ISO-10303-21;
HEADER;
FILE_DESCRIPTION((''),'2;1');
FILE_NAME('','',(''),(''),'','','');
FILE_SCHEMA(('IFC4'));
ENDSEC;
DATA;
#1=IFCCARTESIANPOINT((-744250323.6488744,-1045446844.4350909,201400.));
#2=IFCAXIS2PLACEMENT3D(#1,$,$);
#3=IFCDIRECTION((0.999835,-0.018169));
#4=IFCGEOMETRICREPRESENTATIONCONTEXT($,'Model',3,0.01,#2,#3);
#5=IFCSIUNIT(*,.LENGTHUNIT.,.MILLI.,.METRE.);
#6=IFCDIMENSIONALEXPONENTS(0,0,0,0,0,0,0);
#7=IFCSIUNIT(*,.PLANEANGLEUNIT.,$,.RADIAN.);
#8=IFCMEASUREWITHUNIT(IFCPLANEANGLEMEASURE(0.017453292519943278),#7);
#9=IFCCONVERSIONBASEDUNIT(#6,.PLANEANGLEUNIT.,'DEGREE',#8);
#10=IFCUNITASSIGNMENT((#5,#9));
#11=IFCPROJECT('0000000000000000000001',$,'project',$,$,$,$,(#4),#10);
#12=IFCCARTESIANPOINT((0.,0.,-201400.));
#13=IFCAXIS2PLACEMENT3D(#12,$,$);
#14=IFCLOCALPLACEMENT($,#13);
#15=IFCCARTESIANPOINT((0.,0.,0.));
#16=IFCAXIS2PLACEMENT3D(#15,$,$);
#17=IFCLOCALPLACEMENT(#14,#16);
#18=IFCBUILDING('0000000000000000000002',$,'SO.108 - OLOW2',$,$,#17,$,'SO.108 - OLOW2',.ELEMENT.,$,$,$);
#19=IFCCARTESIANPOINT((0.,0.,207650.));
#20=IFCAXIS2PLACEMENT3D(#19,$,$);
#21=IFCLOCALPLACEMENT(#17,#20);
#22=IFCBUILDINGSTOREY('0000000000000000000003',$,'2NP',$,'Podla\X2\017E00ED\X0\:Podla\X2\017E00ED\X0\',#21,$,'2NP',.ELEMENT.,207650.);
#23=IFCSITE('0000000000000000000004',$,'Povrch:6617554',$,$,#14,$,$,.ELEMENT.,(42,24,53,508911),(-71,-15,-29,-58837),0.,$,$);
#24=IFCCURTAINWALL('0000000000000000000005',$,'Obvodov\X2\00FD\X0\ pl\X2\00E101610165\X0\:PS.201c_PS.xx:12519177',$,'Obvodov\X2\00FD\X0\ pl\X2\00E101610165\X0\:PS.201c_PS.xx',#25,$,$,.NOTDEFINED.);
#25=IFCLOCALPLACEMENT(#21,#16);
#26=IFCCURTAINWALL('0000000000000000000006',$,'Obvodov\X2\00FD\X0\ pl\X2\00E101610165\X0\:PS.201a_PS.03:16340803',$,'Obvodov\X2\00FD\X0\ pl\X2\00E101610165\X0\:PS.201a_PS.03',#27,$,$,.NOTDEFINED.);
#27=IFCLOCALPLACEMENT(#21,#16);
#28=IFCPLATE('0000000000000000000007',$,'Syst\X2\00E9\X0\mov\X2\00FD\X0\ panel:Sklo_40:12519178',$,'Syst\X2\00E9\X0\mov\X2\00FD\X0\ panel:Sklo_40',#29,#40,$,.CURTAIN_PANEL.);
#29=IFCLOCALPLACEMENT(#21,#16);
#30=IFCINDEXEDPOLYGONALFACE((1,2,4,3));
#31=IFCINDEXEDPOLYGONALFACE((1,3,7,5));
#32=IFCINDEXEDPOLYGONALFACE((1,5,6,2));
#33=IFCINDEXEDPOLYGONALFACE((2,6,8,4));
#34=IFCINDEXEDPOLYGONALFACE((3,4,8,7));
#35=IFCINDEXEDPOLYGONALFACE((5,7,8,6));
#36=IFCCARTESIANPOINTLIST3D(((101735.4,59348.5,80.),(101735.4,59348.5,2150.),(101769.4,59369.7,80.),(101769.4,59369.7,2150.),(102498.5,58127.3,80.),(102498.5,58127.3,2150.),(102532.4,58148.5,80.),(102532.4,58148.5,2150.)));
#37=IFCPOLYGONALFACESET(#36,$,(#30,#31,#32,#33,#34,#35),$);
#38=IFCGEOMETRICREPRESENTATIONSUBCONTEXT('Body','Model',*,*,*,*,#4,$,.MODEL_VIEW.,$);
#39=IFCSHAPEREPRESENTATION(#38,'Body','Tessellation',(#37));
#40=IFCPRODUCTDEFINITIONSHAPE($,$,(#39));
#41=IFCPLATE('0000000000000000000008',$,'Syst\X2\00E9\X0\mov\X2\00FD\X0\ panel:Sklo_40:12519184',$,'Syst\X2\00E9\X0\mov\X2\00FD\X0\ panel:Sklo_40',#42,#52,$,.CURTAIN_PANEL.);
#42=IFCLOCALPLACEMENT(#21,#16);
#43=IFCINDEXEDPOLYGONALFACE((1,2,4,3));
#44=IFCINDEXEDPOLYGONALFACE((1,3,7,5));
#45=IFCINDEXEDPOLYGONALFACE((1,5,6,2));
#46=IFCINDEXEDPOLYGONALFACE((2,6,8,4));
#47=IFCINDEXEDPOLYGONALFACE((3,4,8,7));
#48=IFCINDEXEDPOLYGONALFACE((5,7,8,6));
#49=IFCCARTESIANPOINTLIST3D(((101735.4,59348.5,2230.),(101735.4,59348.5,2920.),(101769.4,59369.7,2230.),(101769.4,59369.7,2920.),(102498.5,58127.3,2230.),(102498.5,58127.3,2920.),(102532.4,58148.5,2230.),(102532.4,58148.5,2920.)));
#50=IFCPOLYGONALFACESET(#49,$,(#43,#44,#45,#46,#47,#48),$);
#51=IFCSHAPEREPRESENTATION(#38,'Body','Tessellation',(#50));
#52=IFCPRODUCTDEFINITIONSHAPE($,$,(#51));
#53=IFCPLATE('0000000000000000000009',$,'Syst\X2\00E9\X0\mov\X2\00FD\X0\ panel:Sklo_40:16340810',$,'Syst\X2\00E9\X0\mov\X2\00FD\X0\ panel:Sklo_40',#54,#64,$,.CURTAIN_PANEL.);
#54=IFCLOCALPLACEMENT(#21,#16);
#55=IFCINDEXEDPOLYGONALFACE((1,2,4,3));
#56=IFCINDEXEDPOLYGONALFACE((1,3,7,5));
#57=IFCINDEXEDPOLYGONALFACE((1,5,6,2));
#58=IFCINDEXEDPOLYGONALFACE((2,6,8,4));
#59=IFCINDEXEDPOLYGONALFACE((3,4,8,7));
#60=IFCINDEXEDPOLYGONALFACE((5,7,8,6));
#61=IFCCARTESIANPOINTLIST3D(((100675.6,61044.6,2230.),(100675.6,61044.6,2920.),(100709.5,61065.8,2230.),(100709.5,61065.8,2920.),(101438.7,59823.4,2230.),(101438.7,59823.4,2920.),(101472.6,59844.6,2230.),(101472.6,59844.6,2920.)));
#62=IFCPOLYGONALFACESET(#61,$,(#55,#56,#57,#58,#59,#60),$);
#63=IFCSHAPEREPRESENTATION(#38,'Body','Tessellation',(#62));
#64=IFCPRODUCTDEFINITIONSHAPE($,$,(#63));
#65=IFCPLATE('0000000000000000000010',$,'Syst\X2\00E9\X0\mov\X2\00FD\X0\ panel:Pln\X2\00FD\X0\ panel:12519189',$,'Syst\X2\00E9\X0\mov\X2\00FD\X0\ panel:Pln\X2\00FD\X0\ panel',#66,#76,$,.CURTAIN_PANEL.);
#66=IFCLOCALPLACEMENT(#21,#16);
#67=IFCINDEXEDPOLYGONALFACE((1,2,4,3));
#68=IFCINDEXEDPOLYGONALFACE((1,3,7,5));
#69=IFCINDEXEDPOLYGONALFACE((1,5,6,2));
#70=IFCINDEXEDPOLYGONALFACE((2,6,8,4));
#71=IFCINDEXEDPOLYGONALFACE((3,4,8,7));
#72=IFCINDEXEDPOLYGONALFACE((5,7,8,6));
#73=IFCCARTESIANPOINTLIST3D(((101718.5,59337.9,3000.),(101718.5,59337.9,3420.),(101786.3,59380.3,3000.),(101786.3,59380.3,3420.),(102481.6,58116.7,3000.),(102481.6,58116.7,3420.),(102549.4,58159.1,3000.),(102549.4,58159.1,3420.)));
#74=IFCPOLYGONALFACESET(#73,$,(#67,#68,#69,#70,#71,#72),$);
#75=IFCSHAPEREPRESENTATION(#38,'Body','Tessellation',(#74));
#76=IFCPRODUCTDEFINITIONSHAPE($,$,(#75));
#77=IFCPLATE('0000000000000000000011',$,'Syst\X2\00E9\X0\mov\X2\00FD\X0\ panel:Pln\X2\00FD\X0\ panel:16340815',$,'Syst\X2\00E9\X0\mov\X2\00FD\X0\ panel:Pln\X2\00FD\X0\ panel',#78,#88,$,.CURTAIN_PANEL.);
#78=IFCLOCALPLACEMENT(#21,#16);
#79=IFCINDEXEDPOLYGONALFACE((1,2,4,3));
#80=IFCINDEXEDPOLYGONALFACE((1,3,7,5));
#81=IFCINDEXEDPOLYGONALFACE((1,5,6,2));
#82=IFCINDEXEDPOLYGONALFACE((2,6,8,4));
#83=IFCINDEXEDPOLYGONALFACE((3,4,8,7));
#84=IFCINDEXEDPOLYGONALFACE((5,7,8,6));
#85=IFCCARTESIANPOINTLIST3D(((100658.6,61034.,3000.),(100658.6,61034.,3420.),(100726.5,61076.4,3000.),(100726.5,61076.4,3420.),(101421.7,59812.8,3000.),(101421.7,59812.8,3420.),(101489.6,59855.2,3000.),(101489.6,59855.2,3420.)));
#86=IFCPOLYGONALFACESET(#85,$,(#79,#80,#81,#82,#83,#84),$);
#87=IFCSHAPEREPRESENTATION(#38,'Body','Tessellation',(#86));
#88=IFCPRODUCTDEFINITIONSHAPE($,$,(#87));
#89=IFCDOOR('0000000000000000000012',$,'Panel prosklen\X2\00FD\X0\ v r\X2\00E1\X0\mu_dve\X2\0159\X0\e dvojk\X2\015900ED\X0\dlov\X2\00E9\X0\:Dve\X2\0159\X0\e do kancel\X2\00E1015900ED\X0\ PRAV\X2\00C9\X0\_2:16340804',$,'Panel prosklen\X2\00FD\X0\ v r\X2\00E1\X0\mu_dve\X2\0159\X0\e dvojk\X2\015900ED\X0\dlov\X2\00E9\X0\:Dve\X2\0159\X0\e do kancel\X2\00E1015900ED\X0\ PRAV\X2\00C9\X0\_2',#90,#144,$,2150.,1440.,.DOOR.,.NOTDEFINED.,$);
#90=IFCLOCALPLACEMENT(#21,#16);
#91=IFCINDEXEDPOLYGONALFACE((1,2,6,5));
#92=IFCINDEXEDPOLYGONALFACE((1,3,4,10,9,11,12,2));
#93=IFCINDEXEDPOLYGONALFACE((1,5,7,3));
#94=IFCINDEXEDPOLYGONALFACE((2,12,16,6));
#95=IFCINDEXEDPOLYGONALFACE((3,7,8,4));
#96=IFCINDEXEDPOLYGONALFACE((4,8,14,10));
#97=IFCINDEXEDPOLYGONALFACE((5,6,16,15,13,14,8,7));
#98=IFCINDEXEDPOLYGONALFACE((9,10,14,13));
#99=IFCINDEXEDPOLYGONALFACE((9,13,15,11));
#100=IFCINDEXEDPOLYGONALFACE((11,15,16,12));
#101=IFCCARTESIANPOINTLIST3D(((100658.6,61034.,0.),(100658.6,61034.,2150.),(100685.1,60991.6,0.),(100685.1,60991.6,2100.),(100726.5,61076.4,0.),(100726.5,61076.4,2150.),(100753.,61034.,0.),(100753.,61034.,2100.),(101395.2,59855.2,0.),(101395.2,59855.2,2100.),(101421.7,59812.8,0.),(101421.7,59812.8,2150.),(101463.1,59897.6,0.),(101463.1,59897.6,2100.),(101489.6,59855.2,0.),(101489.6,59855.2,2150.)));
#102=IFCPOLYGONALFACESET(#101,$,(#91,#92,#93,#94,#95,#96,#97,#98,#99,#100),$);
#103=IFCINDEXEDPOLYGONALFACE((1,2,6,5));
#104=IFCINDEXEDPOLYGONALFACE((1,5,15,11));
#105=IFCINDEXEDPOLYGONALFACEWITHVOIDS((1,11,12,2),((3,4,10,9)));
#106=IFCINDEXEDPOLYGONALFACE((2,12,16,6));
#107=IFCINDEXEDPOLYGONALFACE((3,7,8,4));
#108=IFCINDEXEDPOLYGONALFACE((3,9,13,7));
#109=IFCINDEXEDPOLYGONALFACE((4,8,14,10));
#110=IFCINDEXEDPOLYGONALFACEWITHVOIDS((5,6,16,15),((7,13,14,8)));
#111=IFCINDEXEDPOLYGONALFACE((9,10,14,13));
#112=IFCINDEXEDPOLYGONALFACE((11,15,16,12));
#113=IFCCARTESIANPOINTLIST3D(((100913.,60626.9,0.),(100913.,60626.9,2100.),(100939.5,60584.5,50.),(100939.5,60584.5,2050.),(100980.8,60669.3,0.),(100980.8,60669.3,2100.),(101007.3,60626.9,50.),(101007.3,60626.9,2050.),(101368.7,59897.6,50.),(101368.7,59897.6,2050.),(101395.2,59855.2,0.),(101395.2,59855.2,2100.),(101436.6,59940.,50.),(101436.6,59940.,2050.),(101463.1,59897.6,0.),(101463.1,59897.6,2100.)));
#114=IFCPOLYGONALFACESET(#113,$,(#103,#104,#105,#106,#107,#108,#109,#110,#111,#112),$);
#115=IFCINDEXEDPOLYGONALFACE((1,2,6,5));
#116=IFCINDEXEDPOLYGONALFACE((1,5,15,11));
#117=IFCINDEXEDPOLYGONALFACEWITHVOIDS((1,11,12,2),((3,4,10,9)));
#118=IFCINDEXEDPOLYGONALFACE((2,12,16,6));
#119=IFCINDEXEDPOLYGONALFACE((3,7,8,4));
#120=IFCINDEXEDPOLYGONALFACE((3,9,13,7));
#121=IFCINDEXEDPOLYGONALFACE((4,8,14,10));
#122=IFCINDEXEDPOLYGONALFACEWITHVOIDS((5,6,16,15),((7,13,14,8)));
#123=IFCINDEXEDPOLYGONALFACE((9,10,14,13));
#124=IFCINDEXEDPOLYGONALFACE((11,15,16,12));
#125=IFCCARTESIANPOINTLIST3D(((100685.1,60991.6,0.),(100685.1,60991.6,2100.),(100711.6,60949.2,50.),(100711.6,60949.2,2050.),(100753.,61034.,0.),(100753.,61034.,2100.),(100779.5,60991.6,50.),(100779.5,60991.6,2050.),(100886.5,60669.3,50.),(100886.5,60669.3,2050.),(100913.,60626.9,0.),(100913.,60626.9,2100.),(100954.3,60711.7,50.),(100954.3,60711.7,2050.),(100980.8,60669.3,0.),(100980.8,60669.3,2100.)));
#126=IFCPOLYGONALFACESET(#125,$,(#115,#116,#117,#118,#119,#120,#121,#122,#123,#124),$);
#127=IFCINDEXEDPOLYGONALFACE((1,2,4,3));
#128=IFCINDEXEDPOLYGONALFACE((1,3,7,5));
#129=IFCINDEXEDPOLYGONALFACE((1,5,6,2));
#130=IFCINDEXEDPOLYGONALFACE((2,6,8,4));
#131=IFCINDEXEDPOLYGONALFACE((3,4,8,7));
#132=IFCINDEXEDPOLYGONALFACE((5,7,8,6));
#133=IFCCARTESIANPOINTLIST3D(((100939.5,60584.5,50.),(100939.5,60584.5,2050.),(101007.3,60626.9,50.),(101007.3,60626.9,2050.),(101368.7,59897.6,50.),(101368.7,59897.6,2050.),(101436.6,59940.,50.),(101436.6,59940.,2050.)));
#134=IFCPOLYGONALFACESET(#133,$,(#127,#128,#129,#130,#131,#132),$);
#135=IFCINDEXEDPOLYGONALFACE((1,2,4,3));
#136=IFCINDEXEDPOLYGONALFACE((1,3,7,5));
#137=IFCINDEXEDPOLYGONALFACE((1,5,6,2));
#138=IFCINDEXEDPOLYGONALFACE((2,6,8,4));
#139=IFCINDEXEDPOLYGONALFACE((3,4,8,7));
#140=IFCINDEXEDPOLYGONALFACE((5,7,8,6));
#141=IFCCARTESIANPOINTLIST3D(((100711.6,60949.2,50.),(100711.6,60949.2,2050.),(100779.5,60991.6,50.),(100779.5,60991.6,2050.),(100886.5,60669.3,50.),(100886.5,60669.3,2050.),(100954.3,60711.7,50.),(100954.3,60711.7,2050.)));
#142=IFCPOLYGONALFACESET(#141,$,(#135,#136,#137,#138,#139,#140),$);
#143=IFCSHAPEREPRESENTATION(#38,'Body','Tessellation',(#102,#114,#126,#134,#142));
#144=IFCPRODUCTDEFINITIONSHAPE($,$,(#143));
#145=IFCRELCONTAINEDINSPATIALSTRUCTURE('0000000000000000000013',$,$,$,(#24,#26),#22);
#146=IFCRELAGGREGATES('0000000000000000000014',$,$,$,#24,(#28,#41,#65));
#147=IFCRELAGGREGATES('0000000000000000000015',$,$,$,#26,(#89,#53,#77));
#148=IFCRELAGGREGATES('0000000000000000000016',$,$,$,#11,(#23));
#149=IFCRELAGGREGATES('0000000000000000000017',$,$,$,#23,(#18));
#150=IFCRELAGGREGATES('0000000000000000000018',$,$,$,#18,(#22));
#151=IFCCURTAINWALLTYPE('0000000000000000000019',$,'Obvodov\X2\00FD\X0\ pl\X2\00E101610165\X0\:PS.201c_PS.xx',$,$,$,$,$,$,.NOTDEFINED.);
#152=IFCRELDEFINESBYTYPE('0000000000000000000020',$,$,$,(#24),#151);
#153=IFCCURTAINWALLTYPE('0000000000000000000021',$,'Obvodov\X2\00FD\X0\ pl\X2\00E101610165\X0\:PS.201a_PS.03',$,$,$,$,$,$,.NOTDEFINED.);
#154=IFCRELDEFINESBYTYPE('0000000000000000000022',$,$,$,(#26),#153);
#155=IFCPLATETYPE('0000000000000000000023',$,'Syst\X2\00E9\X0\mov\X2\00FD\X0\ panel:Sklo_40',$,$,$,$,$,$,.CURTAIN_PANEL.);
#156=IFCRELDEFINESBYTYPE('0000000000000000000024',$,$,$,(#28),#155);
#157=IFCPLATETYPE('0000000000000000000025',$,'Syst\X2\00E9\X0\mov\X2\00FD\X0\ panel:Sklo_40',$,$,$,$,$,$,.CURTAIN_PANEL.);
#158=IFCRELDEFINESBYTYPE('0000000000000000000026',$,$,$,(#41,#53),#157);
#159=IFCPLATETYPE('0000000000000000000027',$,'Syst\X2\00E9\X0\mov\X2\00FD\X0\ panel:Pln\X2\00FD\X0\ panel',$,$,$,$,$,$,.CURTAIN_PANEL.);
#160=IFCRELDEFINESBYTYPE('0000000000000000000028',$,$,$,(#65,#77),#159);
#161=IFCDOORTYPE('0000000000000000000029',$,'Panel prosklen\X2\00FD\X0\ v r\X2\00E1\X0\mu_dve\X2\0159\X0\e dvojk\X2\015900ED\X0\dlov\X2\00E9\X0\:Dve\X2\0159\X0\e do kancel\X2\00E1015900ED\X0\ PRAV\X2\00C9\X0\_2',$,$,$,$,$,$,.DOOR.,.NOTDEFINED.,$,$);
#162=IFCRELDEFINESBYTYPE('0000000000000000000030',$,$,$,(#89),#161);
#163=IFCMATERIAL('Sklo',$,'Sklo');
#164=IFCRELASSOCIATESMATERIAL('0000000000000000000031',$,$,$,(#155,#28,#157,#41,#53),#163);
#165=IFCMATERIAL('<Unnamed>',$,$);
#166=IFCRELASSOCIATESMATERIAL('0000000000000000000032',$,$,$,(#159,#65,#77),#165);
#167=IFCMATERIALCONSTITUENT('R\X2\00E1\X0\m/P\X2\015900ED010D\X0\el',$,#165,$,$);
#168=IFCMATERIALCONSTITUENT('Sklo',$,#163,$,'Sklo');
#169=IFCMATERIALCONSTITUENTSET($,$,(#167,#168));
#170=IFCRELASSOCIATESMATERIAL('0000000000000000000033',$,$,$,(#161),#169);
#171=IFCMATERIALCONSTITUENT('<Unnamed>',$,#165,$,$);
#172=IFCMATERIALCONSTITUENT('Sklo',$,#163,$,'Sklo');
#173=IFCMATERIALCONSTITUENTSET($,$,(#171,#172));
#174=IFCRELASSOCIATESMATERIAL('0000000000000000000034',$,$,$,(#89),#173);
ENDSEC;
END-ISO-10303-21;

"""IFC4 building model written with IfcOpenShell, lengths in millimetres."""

from ifc_helpers import new_model, entity, si_unit, converted_unit, direction, frame, origin, place, context, subcontext, project, spatial, indexed_curve, outline, extrude, source, transform, mapped, material, constituent, constituent_set, type_object, type_shapes, element, aggregate, save


model = new_model("IFC4")

# Units and contexts
model_context = context("Model", 3, precision=0.01, world=frame((-744250323.6488744, -1045446844.4350909, 201400.0)), true_north=direction((0.999835, -0.018169)))
body_context = subcontext(model_context, "Body", "Model", "MODEL_VIEW")
ifc_project = project(units=[si_unit("LENGTHUNIT", "METRE", prefix="MILLI"), converted_unit("PLANEANGLEUNIT", "DEGREE", entity("IfcPlaneAngleMeasure", 0.017453292519943278), si_unit("PLANEANGLEUNIT", "RADIAN"), dimensions=[0, 0, 0, 0, 0, 0, 0])], contexts=[model_context])

# Site, building, storey
site_placement = place(None, frame((0.0, 0.0, -201400.0)))
site = spatial("IfcSite", under=ifc_project, at=site_placement, Name="Povrch:6617554", CompositionType="ELEMENT", RefLatitude=(42, 24, 53, 508911), RefLongitude=(-71, -15, -29, -58837), RefElevation=0.0)
building_placement = place(site_placement, origin())
building = spatial("IfcBuilding", under=site, at=building_placement, Name="SO.108 - OLOW2", LongName="SO.108 - OLOW2", CompositionType="ELEMENT")
storey_placement = place(building_placement, frame((0.0, 0.0, 207650.0)))
storey = spatial("IfcBuildingStorey", under=building, at=storey_placement, Name="2NP", ObjectType="Podlaží:Podlaží", LongName="2NP", CompositionType="ELEMENT", Elevation=207650.0)

# Shared definitions
ifc_material_1 = material(Name="<Unnamed>")

# Curtain walls
curtain_wall_type_1 = type_object("IfcCurtainWallType", Name="Obvodový plášť:PS.201c_PS.xx", PredefinedType="NOTDEFINED")
curtain_wall_1_placement = place(storey_placement, frame((0.0, 0.0, -207650.0)))
curtain_wall_1 = element("IfcCurtainWall", 1, at=curtain_wall_1_placement, inside=storey, type_object=curtain_wall_type_1, Name="Obvodový plášť:PS.201c_PS.xx:12519177", ObjectType="Obvodový plášť:PS.201c_PS.xx", PredefinedType="NOTDEFINED")
curtain_wall_type_2 = type_object("IfcCurtainWallType", Name="Obvodový plášť:PS.201a_PS.03", PredefinedType="NOTDEFINED")
curtain_wall_2_placement = place(storey_placement, frame((0.0, 0.0, -207650.0)))
curtain_wall_2 = element("IfcCurtainWall", 2, at=curtain_wall_2_placement, inside=storey, type_object=curtain_wall_type_2, Name="Obvodový plášť:PS.201a_PS.03:16340803", ObjectType="Obvodový plášť:PS.201a_PS.03", PredefinedType="NOTDEFINED")

# Plates
ifc_material_2 = material(Name="Sklo", Category="Sklo")
plate_type_1 = type_object("IfcPlateType", Name="Systémový panel:Sklo_40", PredefinedType="CURTAIN_PANEL", material=ifc_material_2)
shared_shape_1 = source(origin(), body_context, "Body", "SweptSolid", [
    extrude(outline(indexed_curve([(-20.0, -720.0), (20.0, -720.0), (20.0, 720.0), (-20.0, 720.0), (-20.0, -720.0)], self_intersect=False)), frame((0.0, 0.0, 0.0), z_axis=(0.0, 0.0, 1.0), x_axis=(0.0, 1.0, 0.0)), (0.0, 0.0, 1.0), 2070.0),
])
type_shapes(plate_type_1, [shared_shape_1])
plate_1_placement = place(curtain_wall_1_placement, frame((102133.9, 58748.5, 207730.0), z_axis=(0.0, 0.0, 1.0), x_axis=(0.529919, -0.848048, 0.0)))
plate_1 = element("IfcPlate", 3, at=plate_1_placement, type_object=plate_type_1, material=ifc_material_2, Name="Systémový panel:Sklo_40:12519178", ObjectType="Systémový panel:Sklo_40", PredefinedType="CURTAIN_PANEL", context=body_context, shape_type="MappedRepresentation", body=[
    mapped(shared_shape_1, transform((0.0, 0.0, 0.0), scale=1.0)),
])
plate_type_2 = type_object("IfcPlateType", Name="Systémový panel:Sklo_40", PredefinedType="CURTAIN_PANEL", material=ifc_material_2)
shared_shape_2 = source(origin(), body_context, "Body", "SweptSolid", [
    extrude(outline(indexed_curve([(-20.0, -720.0), (20.0, -720.0), (20.0, 720.0), (-20.0, 720.0), (-20.0, -720.0)], self_intersect=False)), frame((0.0, 0.0, 0.0), z_axis=(0.0, 0.0, 1.0), x_axis=(0.0, 1.0, 0.0)), (0.0, 0.0, 1.0), 690.0),
])
type_shapes(plate_type_2, [shared_shape_2])
plate_2_placement = place(curtain_wall_1_placement, frame((102133.9, 58748.5, 209880.0), z_axis=(0.0, 0.0, 1.0), x_axis=(0.529919, -0.848048, 0.0)))
plate_2 = element("IfcPlate", 4, at=plate_2_placement, type_object=plate_type_2, material=ifc_material_2, Name="Systémový panel:Sklo_40:12519184", ObjectType="Systémový panel:Sklo_40", PredefinedType="CURTAIN_PANEL", context=body_context, shape_type="MappedRepresentation", body=[
    mapped(shared_shape_2, transform((0.0, 0.0, 0.0), scale=1.0)),
])
plate_3_placement = place(curtain_wall_2_placement, frame((101074.1, 60444.6, 209880.0), z_axis=(0.0, 0.0, 1.0), x_axis=(-0.529919, 0.848048, 0.0)))
plate_3 = element("IfcPlate", 5, at=plate_3_placement, type_object=plate_type_2, material=ifc_material_2, Name="Systémový panel:Sklo_40:16340810", ObjectType="Systémový panel:Sklo_40", PredefinedType="CURTAIN_PANEL", context=body_context, shape_type="MappedRepresentation", body=[
    mapped(shared_shape_2, transform((0.0, 0.0, 0.0), scale=1.0)),
])

# Plates
plate_type_3 = type_object("IfcPlateType", Name="Systémový panel:Plný panel", PredefinedType="CURTAIN_PANEL", material=ifc_material_1)
shared_shape_3 = source(origin(), body_context, "Body", "SweptSolid", [
    extrude(outline(indexed_curve([(-40.0, -720.0), (40.0, -720.0), (40.0, 720.0), (-40.0, 720.0), (-40.0, -720.0)], self_intersect=False)), frame((0.0, 0.0, 0.0), z_axis=(0.0, 0.0, 1.0), x_axis=(0.0, 1.0, 0.0)), (0.0, 0.0, 1.0), 420.0),
])
type_shapes(plate_type_3, [shared_shape_3])
plate_4_placement = place(curtain_wall_1_placement, frame((102133.9, 58748.5, 210650.0), z_axis=(0.0, 0.0, 1.0), x_axis=(0.529919, -0.848048, 0.0)))
plate_4 = element("IfcPlate", 6, at=plate_4_placement, type_object=plate_type_3, material=ifc_material_1, Name="Systémový panel:Plný panel:12519189", ObjectType="Systémový panel:Plný panel", PredefinedType="CURTAIN_PANEL", context=body_context, shape_type="MappedRepresentation", body=[
    mapped(shared_shape_3, transform((0.0, 0.0, 0.0), scale=1.0)),
])
aggregate(curtain_wall_1, [plate_1, plate_2, plate_4])
plate_5_placement = place(curtain_wall_2_placement, frame((101074.1, 60444.6, 210650.0), z_axis=(0.0, 0.0, 1.0), x_axis=(-0.529919, 0.848048, 0.0)))
plate_5 = element("IfcPlate", 7, at=plate_5_placement, type_object=plate_type_3, material=ifc_material_1, Name="Systémový panel:Plný panel:16340815", ObjectType="Systémový panel:Plný panel", PredefinedType="CURTAIN_PANEL", context=body_context, shape_type="MappedRepresentation", body=[
    mapped(shared_shape_3, transform((0.0, 0.0, 0.0), scale=1.0)),
])

# Door
ifc_constituent_1 = constituent(ifc_material_1, Name="<Unnamed>")
ifc_constituent_2 = constituent(ifc_material_2, Name="Sklo", Category="Sklo")
ifc_constituent_set_1 = constituent_set(constituents=[ifc_constituent_1, ifc_constituent_2])
ifc_constituent_3 = constituent(ifc_material_1, Name="Rám/Příčel")
ifc_constituent_4 = constituent(ifc_material_2, Name="Sklo", Category="Sklo")
ifc_constituent_set_2 = constituent_set(constituents=[ifc_constituent_3, ifc_constituent_4])
door_type = type_object("IfcDoorType", Name="Panel prosklený v rámu_dveře dvojkřídlové:Dveře do kanceláří PRAVÉ_2", OperationType="NOTDEFINED", PredefinedType="DOOR", material=ifc_constituent_set_2)
shared_shape_4 = source(origin(), body_context, "Body", "SweptSolid", [
    extrude(outline(indexed_curve([(-720.0, -1087.5), (720.0, -1087.5), (720.0, 1062.5), (670.0, 1062.5), (670.0, -1037.5), (-670.0, -1037.5), (-670.0, 1062.5), (-720.0, 1062.5), (-720.0, -1087.5)], self_intersect=False)), frame((0.0, -40.0, 1062.5), z_axis=(0.0, 1.0, 0.0), x_axis=(1.0, 0.0, 0.0)), (0.0, 0.0, 1.0), 80.0),
    extrude(outline(indexed_curve([(-1050.0, -455.0), (1050.0, -455.0), (1050.0, 455.0), (-1050.0, 455.0), (-1050.0, -455.0)], self_intersect=False), holes=[indexed_curve([(-1000.0, -405.0), (-1000.0, 405.0), (1000.0, 405.0), (1000.0, -405.0), (-1000.0, -405.0)], self_intersect=False)]), frame((215.0, -40.0, 1050.0), z_axis=(0.0, 1.0, 0.0), x_axis=(0.0, 0.0, -1.0)), (0.0, 0.0, 1.0), 80.0),
    extrude(outline(indexed_curve([(-1050.0, -215.0), (1050.0, -215.0), (1050.0, 215.0), (-1050.0, 215.0), (-1050.0, -215.0)], self_intersect=False), holes=[indexed_curve([(-1000.0, -165.0), (-1000.0, 165.0), (1000.0, 165.0), (1000.0, -165.0), (-1000.0, -165.0)], self_intersect=False)]), frame((-455.0, -40.0, 1050.0), z_axis=(0.0, 1.0, 0.0), x_axis=(0.0, 0.0, -1.0)), (0.0, 0.0, 1.0), 80.0),
    extrude(outline(indexed_curve([(-40.0, -405.0), (40.0, -405.0), (40.0, 405.0), (-40.0, 405.0), (-40.0, -405.0)], self_intersect=False)), frame((215.0, 0.0, 50.0), z_axis=(0.0, 0.0, 1.0), x_axis=(0.0, 1.0, 0.0)), (0.0, 0.0, 1.0), 2000.0),
    extrude(outline(indexed_curve([(-40.0, -165.0), (40.0, -165.0), (40.0, 165.0), (-40.0, 165.0), (-40.0, -165.0)], self_intersect=False)), frame((-455.0, 0.0, 50.0), z_axis=(0.0, 0.0, 1.0), x_axis=(0.0, 1.0, 0.0)), (0.0, 0.0, 1.0), 2000.0),
])
type_shapes(door_type, [shared_shape_4])
door_placement = place(curtain_wall_2_placement, frame((101074.1, 60444.6, 207650.0), z_axis=(0.0, 0.0, 1.0), x_axis=(0.529919, -0.848048, 0.0)))
door = element("IfcDoor", 8, at=door_placement, type_object=door_type, material=ifc_constituent_set_1, Name="Panel prosklený v rámu_dveře dvojkřídlové:Dveře do kanceláří PRAVÉ_2:16340804", ObjectType="Panel prosklený v rámu_dveře dvojkřídlové:Dveře do kanceláří PRAVÉ_2", OperationType="NOTDEFINED", OverallHeight=2150.0, OverallWidth=1440.0, PredefinedType="DOOR", context=body_context, shape_type="MappedRepresentation", body=[
    mapped(shared_shape_4, transform((0.0, 0.0, 0.0), scale=1.0)),
])
aggregate(curtain_wall_2, [door, plate_3, plate_5])

save(model, "model.ifc")
